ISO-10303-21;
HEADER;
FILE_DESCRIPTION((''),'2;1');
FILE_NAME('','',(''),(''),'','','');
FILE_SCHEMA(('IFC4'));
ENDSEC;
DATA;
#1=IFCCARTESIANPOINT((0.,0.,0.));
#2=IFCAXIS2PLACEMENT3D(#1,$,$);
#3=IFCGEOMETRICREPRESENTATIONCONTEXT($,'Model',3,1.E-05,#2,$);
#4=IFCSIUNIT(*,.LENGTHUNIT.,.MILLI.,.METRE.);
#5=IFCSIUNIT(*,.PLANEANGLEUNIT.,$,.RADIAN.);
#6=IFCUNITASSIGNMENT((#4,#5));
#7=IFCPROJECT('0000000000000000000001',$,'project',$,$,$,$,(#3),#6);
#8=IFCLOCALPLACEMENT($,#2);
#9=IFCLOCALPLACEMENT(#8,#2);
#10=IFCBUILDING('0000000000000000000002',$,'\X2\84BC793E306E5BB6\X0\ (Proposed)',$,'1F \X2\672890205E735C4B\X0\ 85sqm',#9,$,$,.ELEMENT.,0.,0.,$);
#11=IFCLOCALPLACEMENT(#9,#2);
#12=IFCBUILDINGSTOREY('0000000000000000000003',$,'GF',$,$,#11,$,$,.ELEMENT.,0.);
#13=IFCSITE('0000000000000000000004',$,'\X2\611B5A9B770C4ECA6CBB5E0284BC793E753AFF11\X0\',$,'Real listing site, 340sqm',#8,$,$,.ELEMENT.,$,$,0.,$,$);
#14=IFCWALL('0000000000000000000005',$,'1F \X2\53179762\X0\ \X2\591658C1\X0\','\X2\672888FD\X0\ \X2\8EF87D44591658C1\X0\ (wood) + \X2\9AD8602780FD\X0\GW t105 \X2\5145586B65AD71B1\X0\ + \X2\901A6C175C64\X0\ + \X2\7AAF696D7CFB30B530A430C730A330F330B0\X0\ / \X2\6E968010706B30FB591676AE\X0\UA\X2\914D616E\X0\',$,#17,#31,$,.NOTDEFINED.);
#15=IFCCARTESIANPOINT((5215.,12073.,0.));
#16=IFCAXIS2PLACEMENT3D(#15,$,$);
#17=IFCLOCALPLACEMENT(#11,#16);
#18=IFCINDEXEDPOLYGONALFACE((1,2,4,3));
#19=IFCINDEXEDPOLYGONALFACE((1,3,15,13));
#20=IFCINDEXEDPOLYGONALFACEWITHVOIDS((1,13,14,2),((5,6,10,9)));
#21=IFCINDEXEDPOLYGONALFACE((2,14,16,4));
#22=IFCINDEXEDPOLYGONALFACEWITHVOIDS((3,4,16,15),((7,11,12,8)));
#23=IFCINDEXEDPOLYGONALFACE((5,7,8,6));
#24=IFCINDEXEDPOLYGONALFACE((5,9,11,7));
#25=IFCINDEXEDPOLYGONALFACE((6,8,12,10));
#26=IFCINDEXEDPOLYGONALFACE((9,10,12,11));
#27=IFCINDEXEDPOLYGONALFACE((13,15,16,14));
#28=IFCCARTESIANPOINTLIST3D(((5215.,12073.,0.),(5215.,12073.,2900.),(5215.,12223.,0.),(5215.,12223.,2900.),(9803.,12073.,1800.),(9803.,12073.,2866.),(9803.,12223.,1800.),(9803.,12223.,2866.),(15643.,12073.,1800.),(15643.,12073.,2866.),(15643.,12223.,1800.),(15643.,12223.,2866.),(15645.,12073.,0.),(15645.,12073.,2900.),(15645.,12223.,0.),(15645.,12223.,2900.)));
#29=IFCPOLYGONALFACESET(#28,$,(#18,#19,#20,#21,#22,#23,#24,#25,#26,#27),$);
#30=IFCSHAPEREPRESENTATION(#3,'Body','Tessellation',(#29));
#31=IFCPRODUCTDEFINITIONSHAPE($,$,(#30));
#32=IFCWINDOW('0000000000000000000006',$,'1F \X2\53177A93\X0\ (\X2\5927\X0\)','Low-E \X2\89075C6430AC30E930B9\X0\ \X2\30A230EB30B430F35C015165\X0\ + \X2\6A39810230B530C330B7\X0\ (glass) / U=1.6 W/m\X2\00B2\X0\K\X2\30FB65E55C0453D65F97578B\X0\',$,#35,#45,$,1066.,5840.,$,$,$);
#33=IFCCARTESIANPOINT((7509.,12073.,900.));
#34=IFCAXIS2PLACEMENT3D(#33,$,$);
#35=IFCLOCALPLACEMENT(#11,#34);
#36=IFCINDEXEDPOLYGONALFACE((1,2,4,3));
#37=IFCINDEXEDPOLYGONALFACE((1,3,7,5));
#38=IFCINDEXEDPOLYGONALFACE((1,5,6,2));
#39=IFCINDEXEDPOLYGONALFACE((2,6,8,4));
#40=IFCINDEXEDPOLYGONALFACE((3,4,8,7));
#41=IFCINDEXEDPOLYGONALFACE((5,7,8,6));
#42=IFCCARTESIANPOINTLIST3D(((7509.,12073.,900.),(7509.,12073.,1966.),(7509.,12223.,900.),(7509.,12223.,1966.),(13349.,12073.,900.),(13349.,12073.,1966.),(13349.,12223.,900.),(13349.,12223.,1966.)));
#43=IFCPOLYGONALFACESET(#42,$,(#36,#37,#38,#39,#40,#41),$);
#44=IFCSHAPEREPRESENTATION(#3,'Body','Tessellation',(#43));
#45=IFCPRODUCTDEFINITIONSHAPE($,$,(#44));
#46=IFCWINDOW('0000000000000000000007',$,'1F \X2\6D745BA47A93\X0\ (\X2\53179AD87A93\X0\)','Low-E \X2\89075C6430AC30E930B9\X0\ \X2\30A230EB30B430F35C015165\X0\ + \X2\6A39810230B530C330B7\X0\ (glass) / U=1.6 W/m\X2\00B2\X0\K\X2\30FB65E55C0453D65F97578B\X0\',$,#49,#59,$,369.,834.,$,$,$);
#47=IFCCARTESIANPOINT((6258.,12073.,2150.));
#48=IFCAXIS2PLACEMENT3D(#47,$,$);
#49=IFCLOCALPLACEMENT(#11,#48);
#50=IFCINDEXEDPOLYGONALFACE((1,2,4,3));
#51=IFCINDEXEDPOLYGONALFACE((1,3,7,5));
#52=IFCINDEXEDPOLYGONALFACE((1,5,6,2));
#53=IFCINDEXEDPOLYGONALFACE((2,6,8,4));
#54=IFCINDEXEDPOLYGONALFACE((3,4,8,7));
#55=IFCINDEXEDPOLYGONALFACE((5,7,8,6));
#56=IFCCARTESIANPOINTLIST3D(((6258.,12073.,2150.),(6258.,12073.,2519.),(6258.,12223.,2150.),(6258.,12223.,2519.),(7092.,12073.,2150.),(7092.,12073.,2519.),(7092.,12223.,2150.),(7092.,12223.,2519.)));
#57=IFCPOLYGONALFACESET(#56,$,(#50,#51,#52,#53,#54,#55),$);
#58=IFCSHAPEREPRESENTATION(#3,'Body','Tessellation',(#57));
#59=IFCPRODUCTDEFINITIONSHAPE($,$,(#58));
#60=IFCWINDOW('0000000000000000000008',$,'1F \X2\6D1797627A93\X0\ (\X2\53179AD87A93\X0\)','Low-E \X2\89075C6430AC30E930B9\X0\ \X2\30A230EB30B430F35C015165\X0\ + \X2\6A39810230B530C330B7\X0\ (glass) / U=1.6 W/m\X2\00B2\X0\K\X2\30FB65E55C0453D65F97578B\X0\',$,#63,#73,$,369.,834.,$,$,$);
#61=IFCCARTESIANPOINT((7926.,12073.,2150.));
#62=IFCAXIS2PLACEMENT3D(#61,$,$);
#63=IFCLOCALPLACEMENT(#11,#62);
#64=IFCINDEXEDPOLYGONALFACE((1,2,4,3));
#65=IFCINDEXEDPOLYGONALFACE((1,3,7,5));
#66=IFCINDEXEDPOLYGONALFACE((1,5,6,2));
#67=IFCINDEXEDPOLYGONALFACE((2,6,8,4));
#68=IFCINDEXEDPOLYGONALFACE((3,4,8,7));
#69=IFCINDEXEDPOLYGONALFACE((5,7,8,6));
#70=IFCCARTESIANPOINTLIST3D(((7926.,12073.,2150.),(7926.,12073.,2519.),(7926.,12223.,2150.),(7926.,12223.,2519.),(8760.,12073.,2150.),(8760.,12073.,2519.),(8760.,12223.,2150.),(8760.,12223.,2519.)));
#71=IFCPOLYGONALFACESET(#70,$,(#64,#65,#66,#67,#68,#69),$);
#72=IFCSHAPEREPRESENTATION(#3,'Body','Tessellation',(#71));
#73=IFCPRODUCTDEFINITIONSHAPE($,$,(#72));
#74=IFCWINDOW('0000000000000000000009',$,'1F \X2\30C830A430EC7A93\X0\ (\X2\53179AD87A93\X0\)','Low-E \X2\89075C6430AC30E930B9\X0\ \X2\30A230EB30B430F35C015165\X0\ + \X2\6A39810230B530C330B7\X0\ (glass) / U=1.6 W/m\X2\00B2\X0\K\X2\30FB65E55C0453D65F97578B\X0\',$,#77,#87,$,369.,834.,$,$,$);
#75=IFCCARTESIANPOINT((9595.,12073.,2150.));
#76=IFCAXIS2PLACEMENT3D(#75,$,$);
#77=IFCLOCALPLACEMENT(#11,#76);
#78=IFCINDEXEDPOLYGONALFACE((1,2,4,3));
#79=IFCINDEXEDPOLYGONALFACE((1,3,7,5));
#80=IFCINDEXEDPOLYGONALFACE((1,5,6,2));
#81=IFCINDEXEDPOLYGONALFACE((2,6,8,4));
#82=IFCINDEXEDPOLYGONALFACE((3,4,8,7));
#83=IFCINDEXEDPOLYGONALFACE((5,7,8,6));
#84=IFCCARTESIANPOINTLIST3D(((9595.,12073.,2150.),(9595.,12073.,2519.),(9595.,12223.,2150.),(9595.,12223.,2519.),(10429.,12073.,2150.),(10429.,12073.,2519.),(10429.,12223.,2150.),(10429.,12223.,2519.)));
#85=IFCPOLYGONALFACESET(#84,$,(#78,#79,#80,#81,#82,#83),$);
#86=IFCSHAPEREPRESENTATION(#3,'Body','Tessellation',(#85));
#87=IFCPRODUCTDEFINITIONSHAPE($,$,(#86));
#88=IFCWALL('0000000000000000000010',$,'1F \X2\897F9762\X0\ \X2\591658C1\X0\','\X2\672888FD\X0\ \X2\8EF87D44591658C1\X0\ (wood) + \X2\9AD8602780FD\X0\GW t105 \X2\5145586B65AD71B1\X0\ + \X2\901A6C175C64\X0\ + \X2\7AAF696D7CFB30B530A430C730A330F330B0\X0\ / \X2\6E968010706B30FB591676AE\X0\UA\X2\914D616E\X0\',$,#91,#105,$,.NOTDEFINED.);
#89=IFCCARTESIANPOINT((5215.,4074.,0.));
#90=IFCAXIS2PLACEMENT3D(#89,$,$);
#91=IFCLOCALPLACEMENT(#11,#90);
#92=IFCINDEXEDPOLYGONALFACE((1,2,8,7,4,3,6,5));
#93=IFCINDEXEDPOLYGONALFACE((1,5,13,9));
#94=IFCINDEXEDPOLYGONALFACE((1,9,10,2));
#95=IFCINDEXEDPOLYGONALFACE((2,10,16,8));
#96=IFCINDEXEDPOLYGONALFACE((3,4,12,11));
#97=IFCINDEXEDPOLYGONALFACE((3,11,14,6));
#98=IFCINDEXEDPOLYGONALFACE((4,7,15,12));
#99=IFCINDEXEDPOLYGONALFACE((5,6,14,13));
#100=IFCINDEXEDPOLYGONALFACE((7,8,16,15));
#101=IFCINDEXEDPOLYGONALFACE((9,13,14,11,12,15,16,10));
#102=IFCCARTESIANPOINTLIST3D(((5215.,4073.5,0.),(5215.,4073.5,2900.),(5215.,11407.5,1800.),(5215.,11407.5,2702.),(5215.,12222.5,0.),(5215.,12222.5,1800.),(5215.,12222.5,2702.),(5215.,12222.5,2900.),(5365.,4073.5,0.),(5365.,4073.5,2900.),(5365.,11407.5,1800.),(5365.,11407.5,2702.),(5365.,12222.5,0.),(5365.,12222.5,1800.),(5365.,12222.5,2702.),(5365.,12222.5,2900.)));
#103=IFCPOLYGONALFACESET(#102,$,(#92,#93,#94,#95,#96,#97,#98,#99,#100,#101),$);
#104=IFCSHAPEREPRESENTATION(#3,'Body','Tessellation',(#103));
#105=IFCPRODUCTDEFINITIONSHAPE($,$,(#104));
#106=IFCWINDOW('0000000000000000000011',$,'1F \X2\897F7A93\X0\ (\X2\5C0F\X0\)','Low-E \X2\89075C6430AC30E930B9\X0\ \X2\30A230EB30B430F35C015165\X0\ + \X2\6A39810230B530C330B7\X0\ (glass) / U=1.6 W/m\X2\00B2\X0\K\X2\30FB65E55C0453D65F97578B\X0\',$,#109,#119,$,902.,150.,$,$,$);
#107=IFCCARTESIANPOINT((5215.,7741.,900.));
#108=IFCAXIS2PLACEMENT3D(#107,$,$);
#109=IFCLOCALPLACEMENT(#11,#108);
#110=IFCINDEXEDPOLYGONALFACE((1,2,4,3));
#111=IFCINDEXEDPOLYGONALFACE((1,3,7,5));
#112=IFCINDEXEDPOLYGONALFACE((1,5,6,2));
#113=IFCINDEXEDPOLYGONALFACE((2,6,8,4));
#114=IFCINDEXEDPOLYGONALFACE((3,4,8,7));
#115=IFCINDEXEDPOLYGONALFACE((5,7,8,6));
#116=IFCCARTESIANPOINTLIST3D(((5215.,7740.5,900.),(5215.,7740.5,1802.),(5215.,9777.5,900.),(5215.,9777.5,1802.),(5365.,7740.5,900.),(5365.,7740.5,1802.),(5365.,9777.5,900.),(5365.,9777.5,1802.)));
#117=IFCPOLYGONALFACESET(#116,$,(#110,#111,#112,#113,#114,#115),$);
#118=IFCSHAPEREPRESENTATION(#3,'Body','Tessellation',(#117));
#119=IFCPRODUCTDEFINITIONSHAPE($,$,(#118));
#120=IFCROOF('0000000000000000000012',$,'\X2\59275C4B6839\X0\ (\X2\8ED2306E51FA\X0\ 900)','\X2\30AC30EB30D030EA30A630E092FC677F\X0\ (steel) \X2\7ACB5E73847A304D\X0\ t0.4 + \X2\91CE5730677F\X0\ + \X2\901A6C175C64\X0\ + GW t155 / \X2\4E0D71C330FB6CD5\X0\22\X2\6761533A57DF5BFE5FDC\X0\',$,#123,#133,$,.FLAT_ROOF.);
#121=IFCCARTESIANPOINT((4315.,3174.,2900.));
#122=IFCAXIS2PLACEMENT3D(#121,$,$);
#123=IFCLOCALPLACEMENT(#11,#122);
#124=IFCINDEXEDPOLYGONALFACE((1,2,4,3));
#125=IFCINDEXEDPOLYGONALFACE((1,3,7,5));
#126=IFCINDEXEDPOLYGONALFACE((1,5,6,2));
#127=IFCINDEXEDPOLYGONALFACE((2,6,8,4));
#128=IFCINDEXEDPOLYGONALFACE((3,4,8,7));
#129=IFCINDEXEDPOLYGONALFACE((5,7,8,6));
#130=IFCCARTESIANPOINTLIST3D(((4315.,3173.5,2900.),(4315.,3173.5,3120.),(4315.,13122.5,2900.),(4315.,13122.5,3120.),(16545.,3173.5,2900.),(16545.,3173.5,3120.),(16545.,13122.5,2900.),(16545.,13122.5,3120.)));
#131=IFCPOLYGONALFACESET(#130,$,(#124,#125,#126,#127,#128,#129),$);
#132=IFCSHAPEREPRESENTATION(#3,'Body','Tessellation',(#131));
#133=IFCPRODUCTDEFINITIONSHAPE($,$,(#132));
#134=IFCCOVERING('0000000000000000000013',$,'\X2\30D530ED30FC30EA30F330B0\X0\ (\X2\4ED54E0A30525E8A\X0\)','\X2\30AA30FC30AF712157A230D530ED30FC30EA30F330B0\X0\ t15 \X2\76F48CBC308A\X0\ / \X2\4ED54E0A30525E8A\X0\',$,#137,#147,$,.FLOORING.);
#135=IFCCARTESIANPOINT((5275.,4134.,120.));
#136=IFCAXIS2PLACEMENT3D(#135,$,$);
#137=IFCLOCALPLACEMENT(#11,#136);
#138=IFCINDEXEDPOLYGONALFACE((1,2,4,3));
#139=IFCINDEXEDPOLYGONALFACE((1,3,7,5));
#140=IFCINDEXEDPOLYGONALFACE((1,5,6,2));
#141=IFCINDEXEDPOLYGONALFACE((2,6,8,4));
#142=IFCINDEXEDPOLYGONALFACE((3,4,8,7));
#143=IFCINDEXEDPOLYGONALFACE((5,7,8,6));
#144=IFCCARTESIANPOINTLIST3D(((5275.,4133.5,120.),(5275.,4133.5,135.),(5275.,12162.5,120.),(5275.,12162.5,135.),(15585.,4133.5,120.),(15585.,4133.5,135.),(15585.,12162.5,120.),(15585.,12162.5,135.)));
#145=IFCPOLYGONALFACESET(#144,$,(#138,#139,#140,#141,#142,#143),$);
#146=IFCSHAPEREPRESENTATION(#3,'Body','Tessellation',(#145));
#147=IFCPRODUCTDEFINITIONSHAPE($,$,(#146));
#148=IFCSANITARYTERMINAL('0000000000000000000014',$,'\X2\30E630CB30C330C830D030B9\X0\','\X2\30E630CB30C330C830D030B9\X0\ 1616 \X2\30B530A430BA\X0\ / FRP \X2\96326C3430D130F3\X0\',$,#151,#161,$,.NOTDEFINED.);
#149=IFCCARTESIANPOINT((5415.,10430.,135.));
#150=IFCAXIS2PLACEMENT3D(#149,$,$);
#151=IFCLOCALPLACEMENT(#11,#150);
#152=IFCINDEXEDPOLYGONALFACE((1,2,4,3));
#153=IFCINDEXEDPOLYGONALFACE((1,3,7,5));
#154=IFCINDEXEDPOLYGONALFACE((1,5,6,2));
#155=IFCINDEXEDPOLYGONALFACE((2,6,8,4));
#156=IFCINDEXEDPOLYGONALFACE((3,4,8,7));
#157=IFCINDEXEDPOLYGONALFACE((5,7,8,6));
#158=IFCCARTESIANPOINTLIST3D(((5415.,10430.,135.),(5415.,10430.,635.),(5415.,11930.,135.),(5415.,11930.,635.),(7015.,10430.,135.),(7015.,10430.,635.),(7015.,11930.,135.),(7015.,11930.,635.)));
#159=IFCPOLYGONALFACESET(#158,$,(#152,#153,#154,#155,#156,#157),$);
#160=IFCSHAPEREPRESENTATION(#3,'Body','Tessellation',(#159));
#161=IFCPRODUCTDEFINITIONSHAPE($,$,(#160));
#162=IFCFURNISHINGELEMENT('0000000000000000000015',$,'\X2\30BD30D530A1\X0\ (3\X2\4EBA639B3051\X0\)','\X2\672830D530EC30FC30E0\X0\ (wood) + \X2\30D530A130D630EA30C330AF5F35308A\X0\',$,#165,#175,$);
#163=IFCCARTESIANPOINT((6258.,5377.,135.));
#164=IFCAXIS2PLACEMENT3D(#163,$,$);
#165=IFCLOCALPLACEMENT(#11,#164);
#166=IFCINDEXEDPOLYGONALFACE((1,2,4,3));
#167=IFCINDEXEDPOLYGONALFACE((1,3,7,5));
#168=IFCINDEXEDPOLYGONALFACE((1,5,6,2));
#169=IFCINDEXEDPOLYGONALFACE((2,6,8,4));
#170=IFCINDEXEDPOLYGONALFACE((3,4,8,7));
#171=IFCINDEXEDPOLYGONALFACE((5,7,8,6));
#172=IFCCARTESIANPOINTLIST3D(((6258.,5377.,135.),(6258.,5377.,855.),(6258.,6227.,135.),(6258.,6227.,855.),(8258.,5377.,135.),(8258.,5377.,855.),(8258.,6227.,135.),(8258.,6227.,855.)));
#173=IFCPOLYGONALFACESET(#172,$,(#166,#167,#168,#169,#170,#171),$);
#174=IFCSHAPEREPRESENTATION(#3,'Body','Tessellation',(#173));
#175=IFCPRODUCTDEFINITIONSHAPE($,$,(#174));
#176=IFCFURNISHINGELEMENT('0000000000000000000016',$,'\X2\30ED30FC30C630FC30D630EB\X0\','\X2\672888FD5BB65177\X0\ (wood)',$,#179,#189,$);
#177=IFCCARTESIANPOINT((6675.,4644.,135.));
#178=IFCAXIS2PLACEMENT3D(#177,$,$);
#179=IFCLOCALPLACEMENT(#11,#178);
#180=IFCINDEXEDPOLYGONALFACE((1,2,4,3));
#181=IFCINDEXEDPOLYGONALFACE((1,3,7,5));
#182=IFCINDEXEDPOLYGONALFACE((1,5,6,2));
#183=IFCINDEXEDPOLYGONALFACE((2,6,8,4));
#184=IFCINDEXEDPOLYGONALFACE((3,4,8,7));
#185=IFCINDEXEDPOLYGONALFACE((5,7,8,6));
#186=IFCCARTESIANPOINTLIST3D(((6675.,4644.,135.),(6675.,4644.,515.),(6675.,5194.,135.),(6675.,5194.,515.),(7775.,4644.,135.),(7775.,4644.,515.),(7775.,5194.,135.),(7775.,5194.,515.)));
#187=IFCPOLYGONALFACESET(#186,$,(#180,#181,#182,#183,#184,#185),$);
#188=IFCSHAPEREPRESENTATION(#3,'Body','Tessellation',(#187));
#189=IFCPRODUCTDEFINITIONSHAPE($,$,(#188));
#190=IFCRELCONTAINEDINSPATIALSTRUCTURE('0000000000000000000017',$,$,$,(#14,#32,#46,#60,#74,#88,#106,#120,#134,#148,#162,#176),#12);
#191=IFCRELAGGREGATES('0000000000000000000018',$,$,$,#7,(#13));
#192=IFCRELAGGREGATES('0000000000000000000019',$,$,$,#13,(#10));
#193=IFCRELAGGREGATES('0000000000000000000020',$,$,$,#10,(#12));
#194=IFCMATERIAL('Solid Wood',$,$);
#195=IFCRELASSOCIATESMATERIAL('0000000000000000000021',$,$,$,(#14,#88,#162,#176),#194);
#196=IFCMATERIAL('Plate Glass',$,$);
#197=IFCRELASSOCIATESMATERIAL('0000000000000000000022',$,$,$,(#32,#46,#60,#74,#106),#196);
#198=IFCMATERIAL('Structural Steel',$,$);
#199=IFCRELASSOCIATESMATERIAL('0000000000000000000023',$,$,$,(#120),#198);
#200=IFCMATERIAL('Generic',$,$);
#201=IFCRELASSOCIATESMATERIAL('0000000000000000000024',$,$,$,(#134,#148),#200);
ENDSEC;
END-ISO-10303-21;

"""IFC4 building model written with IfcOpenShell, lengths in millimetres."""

from ifc_helpers import new_model, si_unit, frame, frame_2d, origin, place, context, project, spatial, rectangle, extrude, material, element, fill, save


model = new_model("IFC4")

# Units and contexts
model_context = context("Model", 3, precision=1e-05, world=origin())
ifc_project = project(units=[si_unit("LENGTHUNIT", "METRE", prefix="MILLI"), si_unit("PLANEANGLEUNIT", "RADIAN")], contexts=[model_context])

# Site, building, storey
site_placement = place(None, origin())
site = spatial("IfcSite", under=ifc_project, at=site_placement, Name="愛媛県今治市蒼社町１", ObjectType="Real listing site, 340sqm", CompositionType="ELEMENT", RefElevation=0.0)
building_placement = place(site_placement, origin())
building = spatial("IfcBuilding", under=site, at=building_placement, Name="蒼社の家 (Proposed)", ObjectType="1F 木造平屋 85sqm", CompositionType="ELEMENT", ElevationOfRefHeight=0.0, ElevationOfTerrain=0.0)
storey_placement = place(building_placement, origin())
storey = spatial("IfcBuildingStorey", under=building, at=storey_placement, Name="GF", CompositionType="ELEMENT", Elevation=0.0)

# Shared definitions
ifc_material_1 = material(Name="Solid Wood")

# Shared definitions
ifc_material_2 = material(Name="Plate Glass")

# Wall, openings, windows
wall_1_placement = place(storey_placement, frame((5215.0, 12073.0, 0.0)))
wall_1 = element("IfcWall", 1, at=wall_1_placement, inside=storey, material=ifc_material_1, Name="1F 北面 外壁", Description="木製 軸組外壁 (wood) + 高性能GW t105 充填断熱 + 通気層 + 窯業系サイディング / 準耐火・外皮UA配慮", PredefinedType="NOTDEFINED", context=model_context, shape_type="SweptSolid", body=[
    extrude(rectangle(XDim=10430.0, YDim=150.0, at=frame_2d((5215.0, 75.0))), frame((5215.0, 12073.0, 0.0)), (0.0, 0.0, 1.0), 2900.0),
])
opening_1_placement = place(storey_placement, frame((7509.0, 12073.0, 900.0)))
opening_1 = element("IfcOpeningElement", 2, at=opening_1_placement, cuts=wall_1, PredefinedType="NOTDEFINED", context=model_context, shape_type="SweptSolid", body=[
    extrude(rectangle(XDim=5840.0, YDim=150.0, at=frame_2d((2920.0, 75.0))), frame((7509.0, 12073.0, 900.0)), (0.0, 0.0, 1.0), 1066.0),
])
opening_2_placement = place(storey_placement, frame((6258.0, 12073.0, 2150.0)))
opening_2 = element("IfcOpeningElement", 3, at=opening_2_placement, cuts=wall_1, PredefinedType="NOTDEFINED", context=model_context, shape_type="SweptSolid", body=[
    extrude(rectangle(XDim=834.0, YDim=150.0, at=frame_2d((417.0, 75.0))), frame((6258.0, 12073.0, 2150.0)), (0.0, 0.0, 1.0), 369.0),
])
opening_3_placement = place(storey_placement, frame((7926.0, 12073.0, 2150.0)))
opening_3 = element("IfcOpeningElement", 4, at=opening_3_placement, cuts=wall_1, PredefinedType="NOTDEFINED", context=model_context, shape_type="SweptSolid", body=[
    extrude(rectangle(XDim=834.0, YDim=150.0, at=frame_2d((417.0, 75.0))), frame((7926.0, 12073.0, 2150.0)), (0.0, 0.0, 1.0), 369.0),
])
opening_4_placement = place(storey_placement, frame((9595.0, 12073.0, 2150.0)))
opening_4 = element("IfcOpeningElement", 5, at=opening_4_placement, cuts=wall_1, PredefinedType="NOTDEFINED", context=model_context, shape_type="SweptSolid", body=[
    extrude(rectangle(XDim=834.0, YDim=150.0, at=frame_2d((417.0, 75.0))), frame((9595.0, 12073.0, 2150.0)), (0.0, 0.0, 1.0), 369.0),
])
window_1_placement = place(storey_placement, frame((7509.0, 12073.0, 900.0)))
window_1 = element("IfcWindow", 6, at=window_1_placement, inside=storey, material=ifc_material_2, Name="1F 北窓 (大)", Description="Low-E 複層ガラス アルゴン封入 + 樹脂サッシ (glass) / U=1.6 W/m²K・日射取得型", OverallHeight=1066.0, OverallWidth=5840.0, context=model_context, shape_type="SweptSolid", body=[
    extrude(rectangle(XDim=5840.0, YDim=150.0, at=frame_2d((2920.0, 75.0))), frame((7509.0, 12073.0, 900.0)), (0.0, 0.0, 1.0), 1066.0),
])
fill(opening_1, window_1)
window_2_placement = place(storey_placement, frame((6258.0, 12073.0, 2150.0)))
window_2 = element("IfcWindow", 7, at=window_2_placement, inside=storey, material=ifc_material_2, Name="1F 浴室窓 (北高窓)", Description="Low-E 複層ガラス アルゴン封入 + 樹脂サッシ (glass) / U=1.6 W/m²K・日射取得型", OverallHeight=369.0, OverallWidth=834.0, context=model_context, shape_type="SweptSolid", body=[
    extrude(rectangle(XDim=834.0, YDim=150.0, at=frame_2d((417.0, 75.0))), frame((6258.0, 12073.0, 2150.0)), (0.0, 0.0, 1.0), 369.0),
])
fill(opening_2, window_2)
window_3_placement = place(storey_placement, frame((7926.0, 12073.0, 2150.0)))
window_3 = element("IfcWindow", 8, at=window_3_placement, inside=storey, material=ifc_material_2, Name="1F 洗面窓 (北高窓)", Description="Low-E 複層ガラス アルゴン封入 + 樹脂サッシ (glass) / U=1.6 W/m²K・日射取得型", OverallHeight=369.0, OverallWidth=834.0, context=model_context, shape_type="SweptSolid", body=[
    extrude(rectangle(XDim=834.0, YDim=150.0, at=frame_2d((417.0, 75.0))), frame((7926.0, 12073.0, 2150.0)), (0.0, 0.0, 1.0), 369.0),
])
fill(opening_3, window_3)
window_4_placement = place(storey_placement, frame((9595.0, 12073.0, 2150.0)))
window_4 = element("IfcWindow", 9, at=window_4_placement, inside=storey, material=ifc_material_2, Name="1F トイレ窓 (北高窓)", Description="Low-E 複層ガラス アルゴン封入 + 樹脂サッシ (glass) / U=1.6 W/m²K・日射取得型", OverallHeight=369.0, OverallWidth=834.0, context=model_context, shape_type="SweptSolid", body=[
    extrude(rectangle(XDim=834.0, YDim=150.0, at=frame_2d((417.0, 75.0))), frame((9595.0, 12073.0, 2150.0)), (0.0, 0.0, 1.0), 369.0),
])
fill(opening_4, window_4)

# Wall, opening, window
wall_2_placement = place(storey_placement, frame((5215.0, 4074.0, 0.0)))
wall_2 = element("IfcWall", 10, at=wall_2_placement, inside=storey, material=ifc_material_1, Name="1F 西面 外壁", Description="木製 軸組外壁 (wood) + 高性能GW t105 充填断熱 + 通気層 + 窯業系サイディング / 準耐火・外皮UA配慮", PredefinedType="NOTDEFINED", context=model_context, shape_type="SweptSolid", body=[
    extrude(rectangle(XDim=150.0, YDim=8149.0, at=frame_2d((75.0, 4074.0))), frame((5215.0, 4074.0, 0.0)), (0.0, 0.0, 1.0), 2900.0),
])
opening_5_placement = place(storey_placement, frame((5215.0, 7741.0, 900.0)))
opening_5 = element("IfcOpeningElement", 11, at=opening_5_placement, cuts=wall_2, PredefinedType="NOTDEFINED", context=model_context, shape_type="SweptSolid", body=[
    extrude(rectangle(XDim=150.0, YDim=2037.0, at=frame_2d((75.0, 1018.0))), frame((5215.0, 7741.0, 900.0)), (0.0, 0.0, 1.0), 902.0),
])
window_5_placement = place(storey_placement, frame((5215.0, 7741.0, 900.0)))
window_5 = element("IfcWindow", 12, at=window_5_placement, inside=storey, material=ifc_material_2, Name="1F 西窓 (小)", Description="Low-E 複層ガラス アルゴン封入 + 樹脂サッシ (glass) / U=1.6 W/m²K・日射取得型", OverallHeight=902.0, OverallWidth=150.0, context=model_context, shape_type="SweptSolid", body=[
    extrude(rectangle(XDim=150.0, YDim=2037.0, at=frame_2d((75.0, 1018.0))), frame((5215.0, 7741.0, 900.0)), (0.0, 0.0, 1.0), 902.0),
])
fill(opening_5, window_5)

# Roof
ifc_material_3 = material(Name="Structural Steel")
roof_placement = place(storey_placement, frame((4315.0, 3174.0, 2900.0)))
element("IfcRoof", 13, at=roof_placement, inside=storey, material=ifc_material_3, Name="大屋根 (軒の出 900)", Description="ガルバリウム鋼板 (steel) 立平葺き t0.4 + 野地板 + 通気層 + GW t155 / 不燃・法22条区域対応", PredefinedType="FLAT_ROOF", context=model_context, shape_type="SweptSolid", body=[
    extrude(rectangle(XDim=12230.0, YDim=9949.0, at=frame_2d((6115.0, 4974.0))), frame((4315.0, 3174.0, 2900.0)), (0.0, 0.0, 1.0), 220.0),
])

# Covering
ifc_material_4 = material(Name="Generic")
covering_placement = place(storey_placement, frame((5275.0, 4134.0, 120.0)))
element("IfcCovering", 14, at=covering_placement, inside=storey, material=ifc_material_4, Name="フローリング (仕上げ床)", Description="オーク無垢フローリング t15 直貼り / 仕上げ床", PredefinedType="FLOORING", context=model_context, shape_type="SweptSolid", body=[
    extrude(rectangle(XDim=10310.0, YDim=8029.0, at=frame_2d((5155.0, 4014.0))), frame((5275.0, 4134.0, 120.0)), (0.0, 0.0, 1.0), 15.0),
])

# Sanitary terminal
sanitary_terminal_placement = place(storey_placement, frame((5415.0, 10430.0, 135.0)))
element("IfcSanitaryTerminal", 15, at=sanitary_terminal_placement, inside=storey, material=ifc_material_4, Name="ユニットバス", Description="ユニットバス 1616 サイズ / FRP 防水パン", PredefinedType="NOTDEFINED", context=model_context, shape_type="SweptSolid", body=[
    extrude(rectangle(XDim=1600.0, YDim=1500.0, at=frame_2d((800.0, 750.0))), frame((5415.0, 10430.0, 135.0)), (0.0, 0.0, 1.0), 500.0),
])

# Furnishing elements
furnishing_1_placement = place(storey_placement, frame((6258.0, 5377.0, 135.0)))
element("IfcFurnishingElement", 16, at=furnishing_1_placement, inside=storey, material=ifc_material_1, Name="ソファ (3人掛け)", Description="木フレーム (wood) + ファブリック張り", context=model_context, shape_type="SweptSolid", body=[
    extrude(rectangle(XDim=2000.0, YDim=850.0, at=frame_2d((1000.0, 425.0))), frame((6258.0, 5377.0, 135.0)), (0.0, 0.0, 1.0), 720.0),
])
furnishing_2_placement = place(storey_placement, frame((6675.0, 4644.0, 135.0)))
element("IfcFurnishingElement", 17, at=furnishing_2_placement, inside=storey, material=ifc_material_1, Name="ローテーブル", Description="木製家具 (wood)", context=model_context, shape_type="SweptSolid", body=[
    extrude(rectangle(XDim=1100.0, YDim=550.0, at=frame_2d((550.0, 275.0))), frame((6675.0, 4644.0, 135.0)), (0.0, 0.0, 1.0), 380.0),
])

save(model, "model.ifc")
